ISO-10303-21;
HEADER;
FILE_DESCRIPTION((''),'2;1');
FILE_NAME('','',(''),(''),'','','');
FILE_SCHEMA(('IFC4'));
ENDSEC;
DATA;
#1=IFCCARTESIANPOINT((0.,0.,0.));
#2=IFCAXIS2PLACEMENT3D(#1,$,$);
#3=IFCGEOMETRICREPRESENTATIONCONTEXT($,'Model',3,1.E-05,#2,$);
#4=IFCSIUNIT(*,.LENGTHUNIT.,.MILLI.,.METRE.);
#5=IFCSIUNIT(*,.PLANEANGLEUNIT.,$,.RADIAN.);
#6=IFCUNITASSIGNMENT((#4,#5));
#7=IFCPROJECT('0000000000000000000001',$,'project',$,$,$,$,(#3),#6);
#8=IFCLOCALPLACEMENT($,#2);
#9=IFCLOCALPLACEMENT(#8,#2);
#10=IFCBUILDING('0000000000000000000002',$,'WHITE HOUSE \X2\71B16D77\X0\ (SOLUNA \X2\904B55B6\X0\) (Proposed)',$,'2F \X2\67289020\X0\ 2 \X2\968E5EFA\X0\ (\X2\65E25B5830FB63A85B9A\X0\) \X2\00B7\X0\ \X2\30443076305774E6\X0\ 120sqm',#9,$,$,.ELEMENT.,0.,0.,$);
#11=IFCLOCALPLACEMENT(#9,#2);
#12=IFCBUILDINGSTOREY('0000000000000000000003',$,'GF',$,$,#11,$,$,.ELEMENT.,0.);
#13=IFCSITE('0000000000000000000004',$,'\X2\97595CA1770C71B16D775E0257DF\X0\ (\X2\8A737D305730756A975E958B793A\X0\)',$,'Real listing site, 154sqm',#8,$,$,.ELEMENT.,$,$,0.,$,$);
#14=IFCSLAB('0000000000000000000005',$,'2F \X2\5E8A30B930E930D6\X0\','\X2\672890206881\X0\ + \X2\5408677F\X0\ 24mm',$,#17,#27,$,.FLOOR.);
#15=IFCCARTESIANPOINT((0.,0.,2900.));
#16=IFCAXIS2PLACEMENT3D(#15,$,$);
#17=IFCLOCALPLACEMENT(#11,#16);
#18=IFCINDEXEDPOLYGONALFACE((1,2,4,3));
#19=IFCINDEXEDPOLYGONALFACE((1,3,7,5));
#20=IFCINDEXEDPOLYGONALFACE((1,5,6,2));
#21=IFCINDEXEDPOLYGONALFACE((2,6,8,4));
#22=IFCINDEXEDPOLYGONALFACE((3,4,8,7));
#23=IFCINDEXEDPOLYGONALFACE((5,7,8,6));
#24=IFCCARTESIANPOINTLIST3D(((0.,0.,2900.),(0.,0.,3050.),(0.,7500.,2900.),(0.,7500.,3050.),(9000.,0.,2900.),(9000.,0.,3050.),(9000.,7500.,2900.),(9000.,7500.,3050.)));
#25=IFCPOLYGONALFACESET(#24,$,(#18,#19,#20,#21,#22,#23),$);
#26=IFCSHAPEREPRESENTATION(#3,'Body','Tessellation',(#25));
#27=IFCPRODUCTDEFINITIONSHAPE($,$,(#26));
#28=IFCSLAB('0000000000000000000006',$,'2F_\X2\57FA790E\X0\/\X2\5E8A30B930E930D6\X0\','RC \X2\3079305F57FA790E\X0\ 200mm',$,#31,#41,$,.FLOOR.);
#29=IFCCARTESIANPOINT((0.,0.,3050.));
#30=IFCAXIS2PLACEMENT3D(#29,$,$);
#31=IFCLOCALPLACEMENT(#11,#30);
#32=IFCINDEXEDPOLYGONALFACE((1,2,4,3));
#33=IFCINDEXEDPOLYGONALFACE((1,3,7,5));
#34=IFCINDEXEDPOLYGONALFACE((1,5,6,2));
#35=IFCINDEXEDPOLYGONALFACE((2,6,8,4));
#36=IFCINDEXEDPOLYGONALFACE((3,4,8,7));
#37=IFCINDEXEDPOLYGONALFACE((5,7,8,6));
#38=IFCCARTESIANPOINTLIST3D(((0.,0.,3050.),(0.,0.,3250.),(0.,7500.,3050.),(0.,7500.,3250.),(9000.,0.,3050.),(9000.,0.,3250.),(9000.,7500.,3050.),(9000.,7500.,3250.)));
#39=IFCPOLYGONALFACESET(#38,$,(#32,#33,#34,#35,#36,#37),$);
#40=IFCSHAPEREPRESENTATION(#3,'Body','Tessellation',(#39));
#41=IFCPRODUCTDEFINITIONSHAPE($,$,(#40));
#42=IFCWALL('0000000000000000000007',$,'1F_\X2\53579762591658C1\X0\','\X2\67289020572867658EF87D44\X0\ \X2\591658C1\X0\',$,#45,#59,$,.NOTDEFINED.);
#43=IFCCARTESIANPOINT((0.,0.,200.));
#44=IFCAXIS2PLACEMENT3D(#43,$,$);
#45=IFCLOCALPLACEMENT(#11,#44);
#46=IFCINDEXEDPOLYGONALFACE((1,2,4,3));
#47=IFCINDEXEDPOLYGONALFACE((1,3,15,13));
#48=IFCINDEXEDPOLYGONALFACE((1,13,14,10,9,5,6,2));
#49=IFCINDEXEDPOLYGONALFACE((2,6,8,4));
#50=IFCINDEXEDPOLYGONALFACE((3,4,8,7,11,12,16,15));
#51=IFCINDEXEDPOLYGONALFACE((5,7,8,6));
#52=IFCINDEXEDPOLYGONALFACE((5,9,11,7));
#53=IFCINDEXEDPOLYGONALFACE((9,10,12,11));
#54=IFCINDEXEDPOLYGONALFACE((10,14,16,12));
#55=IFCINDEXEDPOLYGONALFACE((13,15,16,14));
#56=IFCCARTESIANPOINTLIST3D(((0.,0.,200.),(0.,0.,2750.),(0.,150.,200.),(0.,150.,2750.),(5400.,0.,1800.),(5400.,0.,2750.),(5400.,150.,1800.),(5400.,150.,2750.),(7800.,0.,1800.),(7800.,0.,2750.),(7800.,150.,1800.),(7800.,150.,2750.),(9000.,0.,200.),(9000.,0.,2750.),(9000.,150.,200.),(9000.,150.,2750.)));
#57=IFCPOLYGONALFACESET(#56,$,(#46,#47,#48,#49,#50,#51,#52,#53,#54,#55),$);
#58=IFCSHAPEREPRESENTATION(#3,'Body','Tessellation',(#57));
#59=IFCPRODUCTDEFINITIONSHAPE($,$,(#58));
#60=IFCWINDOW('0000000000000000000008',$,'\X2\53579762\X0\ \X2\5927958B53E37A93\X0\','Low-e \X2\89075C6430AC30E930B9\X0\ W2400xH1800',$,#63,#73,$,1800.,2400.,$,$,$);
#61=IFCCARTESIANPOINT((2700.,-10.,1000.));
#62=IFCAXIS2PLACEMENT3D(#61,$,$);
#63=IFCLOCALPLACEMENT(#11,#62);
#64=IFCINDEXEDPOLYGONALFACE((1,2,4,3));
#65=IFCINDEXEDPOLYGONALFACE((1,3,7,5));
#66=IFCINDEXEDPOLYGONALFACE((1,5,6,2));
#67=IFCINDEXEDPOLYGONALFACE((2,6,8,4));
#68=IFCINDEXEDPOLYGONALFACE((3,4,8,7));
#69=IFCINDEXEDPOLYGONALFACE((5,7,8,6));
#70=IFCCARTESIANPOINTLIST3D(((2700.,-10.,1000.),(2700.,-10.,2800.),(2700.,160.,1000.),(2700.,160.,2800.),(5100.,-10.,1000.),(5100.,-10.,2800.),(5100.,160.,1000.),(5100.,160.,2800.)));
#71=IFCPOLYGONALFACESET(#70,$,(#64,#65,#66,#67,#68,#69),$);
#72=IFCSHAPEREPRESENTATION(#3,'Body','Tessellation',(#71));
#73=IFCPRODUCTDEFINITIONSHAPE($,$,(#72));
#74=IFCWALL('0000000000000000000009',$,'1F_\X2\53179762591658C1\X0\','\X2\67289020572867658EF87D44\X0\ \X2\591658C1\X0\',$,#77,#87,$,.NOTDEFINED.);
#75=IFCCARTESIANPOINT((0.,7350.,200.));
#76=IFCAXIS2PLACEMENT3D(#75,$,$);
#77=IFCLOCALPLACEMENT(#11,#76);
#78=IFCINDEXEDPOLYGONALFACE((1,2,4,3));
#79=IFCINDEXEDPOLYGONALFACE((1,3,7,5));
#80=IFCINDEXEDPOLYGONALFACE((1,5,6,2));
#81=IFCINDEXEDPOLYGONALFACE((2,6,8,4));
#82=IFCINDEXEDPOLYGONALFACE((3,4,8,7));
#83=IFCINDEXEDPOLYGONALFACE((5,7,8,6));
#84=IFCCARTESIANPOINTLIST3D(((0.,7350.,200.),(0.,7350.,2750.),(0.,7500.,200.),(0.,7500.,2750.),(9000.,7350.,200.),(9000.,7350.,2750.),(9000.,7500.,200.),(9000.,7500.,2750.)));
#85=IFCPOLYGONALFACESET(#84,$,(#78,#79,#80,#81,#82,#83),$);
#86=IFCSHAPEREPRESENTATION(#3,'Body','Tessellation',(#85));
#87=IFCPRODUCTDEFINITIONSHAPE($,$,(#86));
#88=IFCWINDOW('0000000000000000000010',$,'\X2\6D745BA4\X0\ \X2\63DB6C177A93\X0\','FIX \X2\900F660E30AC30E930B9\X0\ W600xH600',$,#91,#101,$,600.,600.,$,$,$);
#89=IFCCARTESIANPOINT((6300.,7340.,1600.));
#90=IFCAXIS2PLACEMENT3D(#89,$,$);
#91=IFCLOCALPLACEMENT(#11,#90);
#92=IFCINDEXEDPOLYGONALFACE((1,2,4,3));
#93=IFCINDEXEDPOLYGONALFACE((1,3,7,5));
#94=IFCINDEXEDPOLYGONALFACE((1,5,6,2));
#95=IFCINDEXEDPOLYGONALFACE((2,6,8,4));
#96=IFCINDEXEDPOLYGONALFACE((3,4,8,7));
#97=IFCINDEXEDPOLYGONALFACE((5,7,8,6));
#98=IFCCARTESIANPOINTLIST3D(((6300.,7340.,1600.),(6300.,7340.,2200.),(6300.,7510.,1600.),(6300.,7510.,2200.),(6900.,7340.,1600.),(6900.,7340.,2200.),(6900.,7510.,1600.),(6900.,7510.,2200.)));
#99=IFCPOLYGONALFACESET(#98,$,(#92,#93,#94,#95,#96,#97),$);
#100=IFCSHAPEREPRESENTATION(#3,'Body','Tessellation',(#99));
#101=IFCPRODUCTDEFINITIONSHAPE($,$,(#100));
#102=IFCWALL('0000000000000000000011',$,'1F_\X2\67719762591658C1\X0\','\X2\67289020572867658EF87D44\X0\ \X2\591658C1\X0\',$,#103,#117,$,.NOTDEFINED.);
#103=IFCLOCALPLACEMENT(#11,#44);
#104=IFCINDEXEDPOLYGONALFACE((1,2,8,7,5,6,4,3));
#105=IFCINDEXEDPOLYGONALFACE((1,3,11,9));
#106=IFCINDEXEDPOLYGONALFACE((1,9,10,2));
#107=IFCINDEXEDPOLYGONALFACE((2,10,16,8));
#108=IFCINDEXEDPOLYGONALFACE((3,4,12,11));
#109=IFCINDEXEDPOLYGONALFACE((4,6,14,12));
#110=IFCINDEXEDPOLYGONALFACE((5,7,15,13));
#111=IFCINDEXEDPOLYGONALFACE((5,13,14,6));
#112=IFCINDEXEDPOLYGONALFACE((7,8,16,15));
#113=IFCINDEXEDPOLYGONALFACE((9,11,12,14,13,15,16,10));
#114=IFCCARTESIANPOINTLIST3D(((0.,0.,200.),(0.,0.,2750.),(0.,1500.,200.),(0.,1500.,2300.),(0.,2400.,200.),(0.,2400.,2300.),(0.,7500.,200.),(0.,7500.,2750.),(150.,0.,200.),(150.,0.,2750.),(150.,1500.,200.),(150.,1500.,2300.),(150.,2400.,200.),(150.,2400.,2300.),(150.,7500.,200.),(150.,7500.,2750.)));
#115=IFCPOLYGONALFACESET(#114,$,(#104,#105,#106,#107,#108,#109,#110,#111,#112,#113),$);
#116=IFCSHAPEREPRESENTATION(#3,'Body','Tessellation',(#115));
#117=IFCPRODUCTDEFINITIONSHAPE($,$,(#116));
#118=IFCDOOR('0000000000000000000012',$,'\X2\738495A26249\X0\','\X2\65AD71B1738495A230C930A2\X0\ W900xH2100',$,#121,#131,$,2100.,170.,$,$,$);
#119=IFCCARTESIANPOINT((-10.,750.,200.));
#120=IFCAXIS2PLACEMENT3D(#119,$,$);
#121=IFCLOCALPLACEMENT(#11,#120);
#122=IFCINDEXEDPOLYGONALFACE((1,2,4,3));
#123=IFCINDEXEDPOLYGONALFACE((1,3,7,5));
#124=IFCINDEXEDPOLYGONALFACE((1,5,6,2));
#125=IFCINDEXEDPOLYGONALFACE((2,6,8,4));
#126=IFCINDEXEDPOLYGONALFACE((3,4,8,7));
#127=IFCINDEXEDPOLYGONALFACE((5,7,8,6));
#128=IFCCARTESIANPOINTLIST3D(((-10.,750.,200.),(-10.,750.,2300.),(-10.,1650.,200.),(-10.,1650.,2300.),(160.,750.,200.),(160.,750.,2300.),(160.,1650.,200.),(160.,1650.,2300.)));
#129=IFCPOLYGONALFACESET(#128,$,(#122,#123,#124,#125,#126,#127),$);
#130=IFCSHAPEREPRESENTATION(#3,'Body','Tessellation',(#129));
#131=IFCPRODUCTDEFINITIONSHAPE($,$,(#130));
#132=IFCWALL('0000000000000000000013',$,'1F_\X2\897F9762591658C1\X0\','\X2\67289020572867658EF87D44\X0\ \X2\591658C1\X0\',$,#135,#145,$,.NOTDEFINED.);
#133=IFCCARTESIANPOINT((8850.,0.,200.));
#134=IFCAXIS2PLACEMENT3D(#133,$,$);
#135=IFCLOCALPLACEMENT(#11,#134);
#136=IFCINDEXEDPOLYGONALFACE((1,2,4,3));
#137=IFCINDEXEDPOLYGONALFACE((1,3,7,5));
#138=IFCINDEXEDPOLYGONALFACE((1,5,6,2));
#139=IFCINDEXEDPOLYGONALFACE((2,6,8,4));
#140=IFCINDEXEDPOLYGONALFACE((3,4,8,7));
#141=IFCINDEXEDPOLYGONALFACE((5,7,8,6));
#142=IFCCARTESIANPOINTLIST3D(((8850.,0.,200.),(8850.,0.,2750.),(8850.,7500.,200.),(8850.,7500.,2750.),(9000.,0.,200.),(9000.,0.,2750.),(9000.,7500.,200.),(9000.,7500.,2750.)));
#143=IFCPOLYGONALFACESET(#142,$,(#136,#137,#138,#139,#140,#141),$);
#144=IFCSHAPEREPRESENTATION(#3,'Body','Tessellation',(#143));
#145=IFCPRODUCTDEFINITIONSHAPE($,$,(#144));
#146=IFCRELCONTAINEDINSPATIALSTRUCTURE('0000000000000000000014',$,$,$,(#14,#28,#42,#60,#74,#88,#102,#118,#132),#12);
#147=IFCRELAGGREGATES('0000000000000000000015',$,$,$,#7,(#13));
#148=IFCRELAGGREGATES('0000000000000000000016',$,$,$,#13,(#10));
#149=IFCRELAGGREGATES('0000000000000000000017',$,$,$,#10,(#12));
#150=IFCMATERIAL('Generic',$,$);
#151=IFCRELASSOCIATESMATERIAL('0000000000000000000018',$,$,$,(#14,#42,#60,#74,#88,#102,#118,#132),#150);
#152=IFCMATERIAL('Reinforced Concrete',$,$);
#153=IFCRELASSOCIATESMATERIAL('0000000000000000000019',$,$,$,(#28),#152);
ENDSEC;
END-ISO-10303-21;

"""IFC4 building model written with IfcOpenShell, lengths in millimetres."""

from ifc_helpers import new_model, si_unit, frame, frame_2d, origin, place, context, project, spatial, rectangle, extrude, material, element, fill, save


model = new_model("IFC4")

# Units and contexts
model_context = context("Model", 3, precision=1e-05, world=origin())
ifc_project = project(units=[si_unit("LENGTHUNIT", "METRE", prefix="MILLI"), si_unit("PLANEANGLEUNIT", "RADIAN")], contexts=[model_context])

# Site, building, storey
site_placement = place(None, origin())
site = spatial("IfcSite", under=ifc_project, at=site_placement, Name="静岡県熱海市域 (詳細地番非開示)", ObjectType="Real listing site, 154sqm", CompositionType="ELEMENT", RefElevation=0.0)
building_placement = place(site_placement, origin())
building = spatial("IfcBuilding", under=site, at=building_placement, Name="WHITE HOUSE 熱海 (SOLUNA 運営) (Proposed)", ObjectType="2F 木造 2 階建 (既存・推定) · いぶし瓦 120sqm", CompositionType="ELEMENT", ElevationOfRefHeight=0.0, ElevationOfTerrain=0.0)
storey_placement = place(building_placement, origin())
storey = spatial("IfcBuildingStorey", under=building, at=storey_placement, Name="GF", CompositionType="ELEMENT", Elevation=0.0)

# Slabs
ifc_material_1 = material(Name="Reinforced Concrete")
ifc_material_2 = material(Name="Generic")
slab_1_placement = place(storey_placement, frame((0.0, 0.0, 2900.0)))
element("IfcSlab", 1, at=slab_1_placement, inside=storey, material=ifc_material_2, Name="2F 床スラブ", Description="木造梁 + 合板 24mm", PredefinedType="FLOOR", context=model_context, shape_type="SweptSolid", body=[
    extrude(rectangle(XDim=9000.0, YDim=7500.0, at=frame_2d((4500.0, 3750.0))), frame((0.0, 0.0, 2900.0)), (0.0, 0.0, 1.0), 150.0),
])
slab_2_placement = place(storey_placement, frame((0.0, 0.0, 3050.0)))
element("IfcSlab", 2, at=slab_2_placement, inside=storey, material=ifc_material_1, Name="2F_基礎/床スラブ", Description="RC べた基礎 200mm", PredefinedType="FLOOR", context=model_context, shape_type="SweptSolid", body=[
    extrude(rectangle(XDim=9000.0, YDim=7500.0, at=frame_2d((4500.0, 3750.0))), frame((0.0, 0.0, 3050.0)), (0.0, 0.0, 1.0), 200.0),
])

# Walls, openings, windows
wall_1_placement = place(storey_placement, frame((0.0, 0.0, 200.0)))
wall_1 = element("IfcWall", 3, at=wall_1_placement, inside=storey, material=ifc_material_2, Name="1F_南面外壁", Description="木造在来軸組 外壁", PredefinedType="NOTDEFINED", context=model_context, shape_type="SweptSolid", body=[
    extrude(rectangle(XDim=9000.0, YDim=150.0, at=frame_2d((4500.0, 75.0))), frame((0.0, 0.0, 200.0)), (0.0, 0.0, 1.0), 2550.0),
])
opening_1_placement = place(storey_placement, frame((2700.0, -10.0, 1000.0)))
opening_1 = element("IfcOpeningElement", 4, at=opening_1_placement, cuts=wall_1, PredefinedType="NOTDEFINED", context=model_context, shape_type="SweptSolid", body=[
    extrude(rectangle(XDim=2400.0, YDim=170.0, at=frame_2d((1200.0, 85.0))), frame((2700.0, -10.0, 1000.0)), (0.0, 0.0, 1.0), 1800.0),
])
window_1_placement = place(storey_placement, frame((2700.0, -10.0, 1000.0)))
window_1 = element("IfcWindow", 5, at=window_1_placement, inside=storey, material=ifc_material_2, Name="南面 大開口窓", Description="Low-e 複層ガラス W2400xH1800", OverallHeight=1800.0, OverallWidth=2400.0, context=model_context, shape_type="SweptSolid", body=[
    extrude(rectangle(XDim=2400.0, YDim=170.0, at=frame_2d((1200.0, 85.0))), frame((2700.0, -10.0, 1000.0)), (0.0, 0.0, 1.0), 1800.0),
])
fill(opening_1, window_1)
wall_2_placement = place(storey_placement, frame((0.0, 7350.0, 200.0)))
wall_2 = element("IfcWall", 6, at=wall_2_placement, inside=storey, material=ifc_material_2, Name="1F_北面外壁", Description="木造在来軸組 外壁", PredefinedType="NOTDEFINED", context=model_context, shape_type="SweptSolid", body=[
    extrude(rectangle(XDim=9000.0, YDim=150.0, at=frame_2d((4500.0, 75.0))), frame((0.0, 7350.0, 200.0)), (0.0, 0.0, 1.0), 2550.0),
])
opening_2_placement = place(storey_placement, frame((6300.0, 7340.0, 1600.0)))
opening_2 = element("IfcOpeningElement", 7, at=opening_2_placement, cuts=wall_2, PredefinedType="NOTDEFINED", context=model_context, shape_type="SweptSolid", body=[
    extrude(rectangle(XDim=600.0, YDim=170.0, at=frame_2d((300.0, 85.0))), frame((6300.0, 7340.0, 1600.0)), (0.0, 0.0, 1.0), 600.0),
])
window_2_placement = place(storey_placement, frame((6300.0, 7340.0, 1600.0)))
window_2 = element("IfcWindow", 8, at=window_2_placement, inside=storey, material=ifc_material_2, Name="浴室 換気窓", Description="FIX 透明ガラス W600xH600", OverallHeight=600.0, OverallWidth=600.0, context=model_context, shape_type="SweptSolid", body=[
    extrude(rectangle(XDim=600.0, YDim=170.0, at=frame_2d((300.0, 85.0))), frame((6300.0, 7340.0, 1600.0)), (0.0, 0.0, 1.0), 600.0),
])
fill(opening_2, window_2)

# Wall, opening, door
wall_3_placement = place(storey_placement, frame((0.0, 0.0, 200.0)))
wall_3 = element("IfcWall", 9, at=wall_3_placement, inside=storey, material=ifc_material_2, Name="1F_東面外壁", Description="木造在来軸組 外壁", PredefinedType="NOTDEFINED", context=model_context, shape_type="SweptSolid", body=[
    extrude(rectangle(XDim=150.0, YDim=7500.0, at=frame_2d((75.0, 3750.0))), frame((0.0, 0.0, 200.0)), (0.0, 0.0, 1.0), 2550.0),
])
opening_3_placement = place(storey_placement, frame((-10.0, 750.0, 200.0)))
opening_3 = element("IfcOpeningElement", 10, at=opening_3_placement, cuts=wall_3, PredefinedType="NOTDEFINED", context=model_context, shape_type="SweptSolid", body=[
    extrude(rectangle(XDim=170.0, YDim=900.0, at=frame_2d((85.0, 450.0))), frame((-10.0, 750.0, 200.0)), (0.0, 0.0, 1.0), 2100.0),
])
door_placement = place(storey_placement, frame((-10.0, 750.0, 200.0)))
door = element("IfcDoor", 11, at=door_placement, inside=storey, material=ifc_material_2, Name="玄関扉", Description="断熱玄関ドア W900xH2100", OverallHeight=2100.0, OverallWidth=170.0, context=model_context, shape_type="SweptSolid", body=[
    extrude(rectangle(XDim=170.0, YDim=900.0, at=frame_2d((85.0, 450.0))), frame((-10.0, 750.0, 200.0)), (0.0, 0.0, 1.0), 2100.0),
])
fill(opening_3, door)

# Wall
wall_4_placement = place(storey_placement, frame((8850.0, 0.0, 200.0)))
element("IfcWall", 12, at=wall_4_placement, inside=storey, material=ifc_material_2, Name="1F_西面外壁", Description="木造在来軸組 外壁", PredefinedType="NOTDEFINED", context=model_context, shape_type="SweptSolid", body=[
    extrude(rectangle(XDim=150.0, YDim=7500.0, at=frame_2d((75.0, 3750.0))), frame((8850.0, 0.0, 200.0)), (0.0, 0.0, 1.0), 2550.0),
])

save(model, "model.ifc")
